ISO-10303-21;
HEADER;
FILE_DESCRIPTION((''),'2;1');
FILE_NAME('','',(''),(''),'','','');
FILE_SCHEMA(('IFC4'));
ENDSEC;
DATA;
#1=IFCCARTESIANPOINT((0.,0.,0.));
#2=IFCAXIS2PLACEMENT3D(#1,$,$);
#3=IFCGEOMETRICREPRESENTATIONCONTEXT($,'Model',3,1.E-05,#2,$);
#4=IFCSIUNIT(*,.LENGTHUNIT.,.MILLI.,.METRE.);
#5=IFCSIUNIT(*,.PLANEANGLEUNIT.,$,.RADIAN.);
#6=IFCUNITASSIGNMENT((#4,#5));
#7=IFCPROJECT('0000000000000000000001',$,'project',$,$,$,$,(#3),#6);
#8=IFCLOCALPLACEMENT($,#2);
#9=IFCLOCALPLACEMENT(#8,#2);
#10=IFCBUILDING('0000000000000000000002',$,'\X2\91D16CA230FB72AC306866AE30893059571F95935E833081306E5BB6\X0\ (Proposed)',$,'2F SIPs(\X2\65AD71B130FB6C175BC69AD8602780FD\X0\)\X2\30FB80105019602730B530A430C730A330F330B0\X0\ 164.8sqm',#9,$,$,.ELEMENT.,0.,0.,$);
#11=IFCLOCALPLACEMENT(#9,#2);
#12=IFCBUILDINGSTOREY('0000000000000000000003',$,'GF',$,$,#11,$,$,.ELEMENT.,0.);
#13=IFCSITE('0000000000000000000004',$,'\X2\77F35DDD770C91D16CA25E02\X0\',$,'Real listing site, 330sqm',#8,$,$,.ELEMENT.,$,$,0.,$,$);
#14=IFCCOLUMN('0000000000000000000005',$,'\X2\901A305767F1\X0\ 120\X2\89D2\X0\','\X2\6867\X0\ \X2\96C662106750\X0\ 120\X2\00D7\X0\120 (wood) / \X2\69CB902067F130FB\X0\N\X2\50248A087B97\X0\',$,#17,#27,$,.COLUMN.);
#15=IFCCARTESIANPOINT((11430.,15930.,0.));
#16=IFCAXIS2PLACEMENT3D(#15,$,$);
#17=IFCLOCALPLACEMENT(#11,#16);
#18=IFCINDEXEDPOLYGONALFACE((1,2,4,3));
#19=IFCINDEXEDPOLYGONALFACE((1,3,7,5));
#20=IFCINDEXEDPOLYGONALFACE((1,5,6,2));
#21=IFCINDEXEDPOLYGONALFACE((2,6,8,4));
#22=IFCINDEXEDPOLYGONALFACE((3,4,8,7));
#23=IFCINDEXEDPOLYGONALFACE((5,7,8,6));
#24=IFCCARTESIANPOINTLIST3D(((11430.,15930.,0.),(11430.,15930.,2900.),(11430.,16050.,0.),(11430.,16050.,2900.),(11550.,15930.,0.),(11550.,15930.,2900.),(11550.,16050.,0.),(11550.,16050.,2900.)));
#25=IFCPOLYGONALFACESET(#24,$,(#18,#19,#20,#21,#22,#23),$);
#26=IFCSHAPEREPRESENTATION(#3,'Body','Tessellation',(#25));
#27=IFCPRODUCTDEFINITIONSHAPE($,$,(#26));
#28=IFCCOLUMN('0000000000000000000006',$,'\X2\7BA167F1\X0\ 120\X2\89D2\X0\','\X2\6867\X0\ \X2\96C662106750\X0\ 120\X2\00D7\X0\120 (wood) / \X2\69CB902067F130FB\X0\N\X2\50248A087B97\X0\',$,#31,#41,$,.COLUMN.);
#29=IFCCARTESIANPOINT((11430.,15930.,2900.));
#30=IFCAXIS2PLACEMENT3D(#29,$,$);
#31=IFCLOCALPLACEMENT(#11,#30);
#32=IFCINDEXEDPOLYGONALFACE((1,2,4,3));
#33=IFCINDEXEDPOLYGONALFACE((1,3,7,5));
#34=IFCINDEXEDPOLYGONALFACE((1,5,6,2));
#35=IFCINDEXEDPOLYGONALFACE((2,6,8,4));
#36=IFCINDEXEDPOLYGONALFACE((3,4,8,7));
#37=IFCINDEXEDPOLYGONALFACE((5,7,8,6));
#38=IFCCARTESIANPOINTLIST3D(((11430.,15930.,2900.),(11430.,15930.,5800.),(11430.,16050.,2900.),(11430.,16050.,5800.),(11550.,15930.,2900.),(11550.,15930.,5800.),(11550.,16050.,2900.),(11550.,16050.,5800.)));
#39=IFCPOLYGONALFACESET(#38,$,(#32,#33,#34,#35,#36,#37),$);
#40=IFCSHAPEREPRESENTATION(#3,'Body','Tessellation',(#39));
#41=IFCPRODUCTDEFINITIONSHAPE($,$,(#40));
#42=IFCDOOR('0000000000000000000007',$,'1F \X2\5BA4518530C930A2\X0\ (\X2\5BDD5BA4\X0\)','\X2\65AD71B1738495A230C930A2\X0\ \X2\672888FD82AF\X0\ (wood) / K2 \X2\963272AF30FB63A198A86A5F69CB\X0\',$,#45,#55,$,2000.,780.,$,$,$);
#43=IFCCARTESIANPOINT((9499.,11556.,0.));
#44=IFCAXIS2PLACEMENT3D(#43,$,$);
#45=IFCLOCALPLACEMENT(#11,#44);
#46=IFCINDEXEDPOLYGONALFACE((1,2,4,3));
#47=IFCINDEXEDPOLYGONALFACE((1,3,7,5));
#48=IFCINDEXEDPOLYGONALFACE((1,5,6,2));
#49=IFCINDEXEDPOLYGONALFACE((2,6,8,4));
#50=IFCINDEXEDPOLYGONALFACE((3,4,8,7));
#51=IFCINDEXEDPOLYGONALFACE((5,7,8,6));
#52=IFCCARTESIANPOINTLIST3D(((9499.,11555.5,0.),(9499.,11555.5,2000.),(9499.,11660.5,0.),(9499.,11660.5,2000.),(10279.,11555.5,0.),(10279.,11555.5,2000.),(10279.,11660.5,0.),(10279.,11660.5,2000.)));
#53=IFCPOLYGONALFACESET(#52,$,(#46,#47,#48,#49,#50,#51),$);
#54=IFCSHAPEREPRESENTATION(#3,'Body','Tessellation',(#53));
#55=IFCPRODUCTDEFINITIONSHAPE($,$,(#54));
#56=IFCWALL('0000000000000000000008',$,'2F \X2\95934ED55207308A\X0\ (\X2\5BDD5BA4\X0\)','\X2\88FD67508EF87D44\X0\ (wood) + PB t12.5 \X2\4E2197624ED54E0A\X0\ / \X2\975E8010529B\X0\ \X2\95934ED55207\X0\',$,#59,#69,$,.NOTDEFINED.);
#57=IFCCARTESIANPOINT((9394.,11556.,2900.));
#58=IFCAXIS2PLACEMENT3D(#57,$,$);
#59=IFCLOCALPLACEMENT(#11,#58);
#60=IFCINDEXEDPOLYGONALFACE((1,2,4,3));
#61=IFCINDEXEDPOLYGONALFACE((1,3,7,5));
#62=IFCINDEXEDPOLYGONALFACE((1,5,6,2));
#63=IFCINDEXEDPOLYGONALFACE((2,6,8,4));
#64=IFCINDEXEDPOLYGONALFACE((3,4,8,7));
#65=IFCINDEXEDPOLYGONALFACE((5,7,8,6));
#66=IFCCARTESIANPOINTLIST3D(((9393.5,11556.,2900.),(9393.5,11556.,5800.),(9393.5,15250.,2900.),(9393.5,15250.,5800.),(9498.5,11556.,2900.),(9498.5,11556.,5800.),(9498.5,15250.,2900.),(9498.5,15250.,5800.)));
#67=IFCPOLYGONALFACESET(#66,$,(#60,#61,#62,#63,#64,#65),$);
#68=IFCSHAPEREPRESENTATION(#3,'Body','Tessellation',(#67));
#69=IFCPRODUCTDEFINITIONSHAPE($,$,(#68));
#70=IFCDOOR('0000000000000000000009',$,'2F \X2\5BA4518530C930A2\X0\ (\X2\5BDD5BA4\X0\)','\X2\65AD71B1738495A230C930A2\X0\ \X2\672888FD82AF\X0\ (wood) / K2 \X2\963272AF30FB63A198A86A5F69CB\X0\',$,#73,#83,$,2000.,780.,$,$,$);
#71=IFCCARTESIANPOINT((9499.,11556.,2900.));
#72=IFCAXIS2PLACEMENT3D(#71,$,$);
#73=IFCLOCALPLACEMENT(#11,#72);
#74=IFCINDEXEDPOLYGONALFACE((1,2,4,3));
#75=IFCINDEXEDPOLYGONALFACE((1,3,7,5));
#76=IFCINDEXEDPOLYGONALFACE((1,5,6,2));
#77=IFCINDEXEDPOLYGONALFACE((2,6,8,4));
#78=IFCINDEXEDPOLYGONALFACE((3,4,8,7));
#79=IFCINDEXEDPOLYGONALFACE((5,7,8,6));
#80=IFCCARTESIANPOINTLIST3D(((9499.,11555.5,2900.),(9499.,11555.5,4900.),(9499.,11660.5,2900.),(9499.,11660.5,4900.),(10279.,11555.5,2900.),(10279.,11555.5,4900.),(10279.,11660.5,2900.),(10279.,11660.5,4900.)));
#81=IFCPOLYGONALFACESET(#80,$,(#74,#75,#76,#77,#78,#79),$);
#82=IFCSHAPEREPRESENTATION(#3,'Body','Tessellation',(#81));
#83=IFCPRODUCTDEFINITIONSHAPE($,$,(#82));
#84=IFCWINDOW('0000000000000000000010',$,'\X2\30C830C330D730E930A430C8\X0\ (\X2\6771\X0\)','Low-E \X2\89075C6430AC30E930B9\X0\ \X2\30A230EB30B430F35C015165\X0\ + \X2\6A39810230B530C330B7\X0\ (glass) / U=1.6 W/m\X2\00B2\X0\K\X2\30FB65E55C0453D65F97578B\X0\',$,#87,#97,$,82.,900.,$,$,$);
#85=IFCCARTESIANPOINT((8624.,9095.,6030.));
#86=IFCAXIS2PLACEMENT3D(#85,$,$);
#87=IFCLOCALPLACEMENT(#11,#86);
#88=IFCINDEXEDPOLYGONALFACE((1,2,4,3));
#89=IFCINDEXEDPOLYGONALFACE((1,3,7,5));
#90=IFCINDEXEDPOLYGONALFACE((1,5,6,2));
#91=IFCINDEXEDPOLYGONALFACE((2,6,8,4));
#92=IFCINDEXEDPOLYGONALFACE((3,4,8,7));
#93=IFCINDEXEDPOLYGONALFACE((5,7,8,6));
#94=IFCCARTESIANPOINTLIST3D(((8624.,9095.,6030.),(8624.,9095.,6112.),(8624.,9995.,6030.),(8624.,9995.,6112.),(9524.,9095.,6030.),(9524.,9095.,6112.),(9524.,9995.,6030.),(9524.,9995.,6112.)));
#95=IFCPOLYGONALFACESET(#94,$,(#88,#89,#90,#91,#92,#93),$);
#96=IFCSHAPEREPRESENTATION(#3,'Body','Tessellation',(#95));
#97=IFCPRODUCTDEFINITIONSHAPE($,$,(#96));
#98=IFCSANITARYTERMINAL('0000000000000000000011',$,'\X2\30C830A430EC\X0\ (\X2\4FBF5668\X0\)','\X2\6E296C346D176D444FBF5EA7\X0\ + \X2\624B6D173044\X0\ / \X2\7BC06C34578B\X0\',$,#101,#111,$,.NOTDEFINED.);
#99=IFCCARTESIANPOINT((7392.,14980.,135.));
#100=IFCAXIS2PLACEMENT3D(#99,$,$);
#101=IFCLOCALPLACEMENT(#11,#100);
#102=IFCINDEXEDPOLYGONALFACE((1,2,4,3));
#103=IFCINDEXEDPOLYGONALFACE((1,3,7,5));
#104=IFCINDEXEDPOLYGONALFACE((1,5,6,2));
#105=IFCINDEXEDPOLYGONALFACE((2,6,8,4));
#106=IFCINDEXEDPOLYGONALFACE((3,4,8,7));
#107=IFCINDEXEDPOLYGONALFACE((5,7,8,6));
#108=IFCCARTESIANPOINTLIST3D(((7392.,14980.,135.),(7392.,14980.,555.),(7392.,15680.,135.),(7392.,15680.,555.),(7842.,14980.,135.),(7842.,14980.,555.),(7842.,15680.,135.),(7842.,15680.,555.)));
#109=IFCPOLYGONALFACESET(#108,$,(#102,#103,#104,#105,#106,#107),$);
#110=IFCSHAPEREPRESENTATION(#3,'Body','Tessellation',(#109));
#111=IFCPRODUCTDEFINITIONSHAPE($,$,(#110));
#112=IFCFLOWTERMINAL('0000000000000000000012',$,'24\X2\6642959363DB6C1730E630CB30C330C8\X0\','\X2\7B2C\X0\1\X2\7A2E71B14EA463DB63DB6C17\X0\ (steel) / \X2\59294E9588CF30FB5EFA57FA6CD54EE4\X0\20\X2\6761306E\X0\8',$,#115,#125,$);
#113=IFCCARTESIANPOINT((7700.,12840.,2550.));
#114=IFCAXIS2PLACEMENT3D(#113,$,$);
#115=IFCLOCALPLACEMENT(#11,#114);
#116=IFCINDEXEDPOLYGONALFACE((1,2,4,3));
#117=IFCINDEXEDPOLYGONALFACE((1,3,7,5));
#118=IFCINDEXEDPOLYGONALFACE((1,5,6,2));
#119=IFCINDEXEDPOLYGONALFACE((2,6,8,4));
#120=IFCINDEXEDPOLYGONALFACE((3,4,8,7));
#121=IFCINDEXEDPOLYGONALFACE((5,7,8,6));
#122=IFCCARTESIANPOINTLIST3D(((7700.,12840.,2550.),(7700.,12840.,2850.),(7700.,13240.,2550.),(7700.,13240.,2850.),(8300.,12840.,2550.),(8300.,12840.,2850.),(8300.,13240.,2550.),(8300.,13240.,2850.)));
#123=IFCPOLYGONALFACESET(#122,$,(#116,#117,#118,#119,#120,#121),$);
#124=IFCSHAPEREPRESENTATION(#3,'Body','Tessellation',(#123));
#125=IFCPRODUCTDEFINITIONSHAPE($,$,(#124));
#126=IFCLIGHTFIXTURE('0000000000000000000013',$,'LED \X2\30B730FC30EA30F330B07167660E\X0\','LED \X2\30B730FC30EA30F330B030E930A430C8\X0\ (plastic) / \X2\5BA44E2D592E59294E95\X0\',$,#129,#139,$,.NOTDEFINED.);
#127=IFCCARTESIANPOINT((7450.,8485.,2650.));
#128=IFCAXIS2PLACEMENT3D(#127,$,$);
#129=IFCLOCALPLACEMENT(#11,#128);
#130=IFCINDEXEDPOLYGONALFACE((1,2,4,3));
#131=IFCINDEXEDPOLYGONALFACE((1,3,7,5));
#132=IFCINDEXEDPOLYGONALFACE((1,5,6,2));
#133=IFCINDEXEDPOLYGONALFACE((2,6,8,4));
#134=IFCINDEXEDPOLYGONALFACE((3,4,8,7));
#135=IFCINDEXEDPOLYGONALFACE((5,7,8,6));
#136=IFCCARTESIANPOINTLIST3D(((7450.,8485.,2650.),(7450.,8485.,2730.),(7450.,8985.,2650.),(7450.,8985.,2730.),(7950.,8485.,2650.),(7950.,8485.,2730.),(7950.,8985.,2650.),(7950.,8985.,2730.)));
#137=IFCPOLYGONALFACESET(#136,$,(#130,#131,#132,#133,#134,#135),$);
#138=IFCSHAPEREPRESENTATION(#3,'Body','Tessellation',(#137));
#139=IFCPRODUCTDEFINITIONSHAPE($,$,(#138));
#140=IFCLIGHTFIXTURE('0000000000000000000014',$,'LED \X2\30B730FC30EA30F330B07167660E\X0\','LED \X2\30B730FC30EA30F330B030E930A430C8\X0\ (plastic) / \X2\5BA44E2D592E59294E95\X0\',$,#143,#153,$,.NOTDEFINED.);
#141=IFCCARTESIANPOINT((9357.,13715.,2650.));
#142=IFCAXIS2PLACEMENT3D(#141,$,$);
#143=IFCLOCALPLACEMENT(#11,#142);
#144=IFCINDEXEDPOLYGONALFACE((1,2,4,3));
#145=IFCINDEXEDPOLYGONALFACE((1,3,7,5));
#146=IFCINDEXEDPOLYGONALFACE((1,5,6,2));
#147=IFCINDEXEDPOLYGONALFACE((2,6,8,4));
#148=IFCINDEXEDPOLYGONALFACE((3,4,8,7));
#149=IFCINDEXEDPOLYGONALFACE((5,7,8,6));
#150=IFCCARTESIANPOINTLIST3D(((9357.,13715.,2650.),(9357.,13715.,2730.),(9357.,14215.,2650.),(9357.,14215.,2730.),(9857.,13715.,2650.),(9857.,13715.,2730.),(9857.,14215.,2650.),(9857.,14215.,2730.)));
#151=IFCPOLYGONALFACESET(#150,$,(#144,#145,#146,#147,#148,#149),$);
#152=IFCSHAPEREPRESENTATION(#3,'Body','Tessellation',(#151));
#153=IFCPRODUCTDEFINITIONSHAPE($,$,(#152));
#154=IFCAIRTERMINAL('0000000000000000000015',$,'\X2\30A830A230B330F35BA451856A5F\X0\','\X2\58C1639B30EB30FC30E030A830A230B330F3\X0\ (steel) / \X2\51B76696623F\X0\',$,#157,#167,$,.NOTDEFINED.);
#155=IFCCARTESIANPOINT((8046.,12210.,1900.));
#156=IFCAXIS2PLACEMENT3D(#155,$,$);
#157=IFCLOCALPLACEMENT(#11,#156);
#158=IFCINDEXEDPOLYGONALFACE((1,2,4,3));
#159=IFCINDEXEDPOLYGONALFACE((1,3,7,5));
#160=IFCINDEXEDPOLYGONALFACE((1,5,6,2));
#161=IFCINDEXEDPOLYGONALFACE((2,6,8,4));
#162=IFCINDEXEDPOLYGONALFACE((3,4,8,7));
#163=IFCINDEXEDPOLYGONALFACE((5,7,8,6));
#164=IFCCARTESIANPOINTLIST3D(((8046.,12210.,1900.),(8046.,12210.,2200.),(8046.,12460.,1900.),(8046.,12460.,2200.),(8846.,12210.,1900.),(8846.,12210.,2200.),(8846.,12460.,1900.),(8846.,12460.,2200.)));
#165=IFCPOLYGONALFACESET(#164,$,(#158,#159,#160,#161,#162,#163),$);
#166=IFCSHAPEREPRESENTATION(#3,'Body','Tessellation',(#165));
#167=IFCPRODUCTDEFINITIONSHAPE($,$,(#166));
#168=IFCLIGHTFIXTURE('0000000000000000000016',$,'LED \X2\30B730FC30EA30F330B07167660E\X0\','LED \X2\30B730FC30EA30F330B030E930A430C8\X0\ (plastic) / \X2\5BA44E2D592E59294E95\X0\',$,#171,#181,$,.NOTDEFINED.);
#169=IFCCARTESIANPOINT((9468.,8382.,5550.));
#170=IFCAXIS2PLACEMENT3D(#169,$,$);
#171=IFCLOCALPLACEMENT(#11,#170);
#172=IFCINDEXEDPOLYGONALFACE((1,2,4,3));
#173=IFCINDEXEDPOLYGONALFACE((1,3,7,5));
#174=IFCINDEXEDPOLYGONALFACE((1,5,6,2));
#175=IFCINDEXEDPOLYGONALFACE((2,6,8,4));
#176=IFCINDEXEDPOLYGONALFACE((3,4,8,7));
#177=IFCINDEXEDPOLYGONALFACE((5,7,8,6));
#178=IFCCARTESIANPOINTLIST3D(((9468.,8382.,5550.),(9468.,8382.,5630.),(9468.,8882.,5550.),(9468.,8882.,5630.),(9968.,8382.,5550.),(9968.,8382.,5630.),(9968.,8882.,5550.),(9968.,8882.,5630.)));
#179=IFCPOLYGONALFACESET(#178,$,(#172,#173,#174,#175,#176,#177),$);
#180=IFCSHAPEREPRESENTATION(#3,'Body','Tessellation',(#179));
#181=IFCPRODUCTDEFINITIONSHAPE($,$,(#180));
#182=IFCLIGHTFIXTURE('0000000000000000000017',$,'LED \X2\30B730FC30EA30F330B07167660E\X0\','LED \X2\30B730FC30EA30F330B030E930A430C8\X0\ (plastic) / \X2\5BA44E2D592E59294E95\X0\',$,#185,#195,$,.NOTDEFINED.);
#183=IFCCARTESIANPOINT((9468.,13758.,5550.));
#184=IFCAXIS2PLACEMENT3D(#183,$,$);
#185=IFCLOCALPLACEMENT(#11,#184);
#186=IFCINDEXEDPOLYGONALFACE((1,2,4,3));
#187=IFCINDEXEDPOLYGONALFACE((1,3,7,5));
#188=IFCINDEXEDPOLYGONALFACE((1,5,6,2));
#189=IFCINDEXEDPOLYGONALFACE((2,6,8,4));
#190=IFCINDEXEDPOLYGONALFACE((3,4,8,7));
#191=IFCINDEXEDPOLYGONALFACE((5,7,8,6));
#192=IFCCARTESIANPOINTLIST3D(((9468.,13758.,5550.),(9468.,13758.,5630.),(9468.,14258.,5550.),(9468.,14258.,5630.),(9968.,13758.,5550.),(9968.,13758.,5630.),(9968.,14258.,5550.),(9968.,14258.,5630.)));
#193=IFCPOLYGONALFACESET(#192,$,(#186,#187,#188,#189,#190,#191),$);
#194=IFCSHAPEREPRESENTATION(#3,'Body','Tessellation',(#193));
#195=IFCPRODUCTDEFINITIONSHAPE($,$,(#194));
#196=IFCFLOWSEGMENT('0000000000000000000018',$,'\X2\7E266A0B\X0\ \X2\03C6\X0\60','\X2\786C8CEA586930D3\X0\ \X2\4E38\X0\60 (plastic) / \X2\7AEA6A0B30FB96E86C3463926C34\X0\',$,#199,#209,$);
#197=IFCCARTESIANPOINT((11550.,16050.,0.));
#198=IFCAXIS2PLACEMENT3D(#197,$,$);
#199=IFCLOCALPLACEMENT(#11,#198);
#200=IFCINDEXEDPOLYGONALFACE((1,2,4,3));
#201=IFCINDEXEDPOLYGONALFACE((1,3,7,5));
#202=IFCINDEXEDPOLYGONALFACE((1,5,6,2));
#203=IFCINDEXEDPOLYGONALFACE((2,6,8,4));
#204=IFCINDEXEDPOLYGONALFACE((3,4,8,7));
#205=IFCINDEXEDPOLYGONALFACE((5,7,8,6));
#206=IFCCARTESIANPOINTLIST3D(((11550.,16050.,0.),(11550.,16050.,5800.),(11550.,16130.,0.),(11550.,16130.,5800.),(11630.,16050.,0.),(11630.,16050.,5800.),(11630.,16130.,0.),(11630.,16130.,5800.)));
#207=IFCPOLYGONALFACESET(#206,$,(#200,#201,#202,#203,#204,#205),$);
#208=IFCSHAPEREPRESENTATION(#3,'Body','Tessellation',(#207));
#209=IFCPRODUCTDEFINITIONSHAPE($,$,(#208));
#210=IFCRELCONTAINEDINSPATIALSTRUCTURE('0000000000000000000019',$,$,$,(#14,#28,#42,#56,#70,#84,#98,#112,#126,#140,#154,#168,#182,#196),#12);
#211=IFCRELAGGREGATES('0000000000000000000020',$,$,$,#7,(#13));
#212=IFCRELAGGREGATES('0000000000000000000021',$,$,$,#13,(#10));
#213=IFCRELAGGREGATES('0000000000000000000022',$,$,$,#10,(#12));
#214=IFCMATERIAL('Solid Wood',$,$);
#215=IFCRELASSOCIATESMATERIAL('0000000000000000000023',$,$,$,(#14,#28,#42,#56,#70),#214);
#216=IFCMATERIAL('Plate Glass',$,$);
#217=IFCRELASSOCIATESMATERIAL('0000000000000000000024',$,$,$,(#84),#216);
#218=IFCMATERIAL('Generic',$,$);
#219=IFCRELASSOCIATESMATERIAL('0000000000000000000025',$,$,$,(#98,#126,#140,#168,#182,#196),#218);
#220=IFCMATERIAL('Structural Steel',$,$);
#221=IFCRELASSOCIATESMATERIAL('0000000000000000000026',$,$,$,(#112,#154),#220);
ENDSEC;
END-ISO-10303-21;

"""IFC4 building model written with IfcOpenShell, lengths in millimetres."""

from ifc_helpers import new_model, si_unit, frame, frame_2d, origin, place, context, project, spatial, rectangle, extrude, material, element, save


model = new_model("IFC4")

# Units and contexts
model_context = context("Model", 3, precision=1e-05, world=origin())
ifc_project = project(units=[si_unit("LENGTHUNIT", "METRE", prefix="MILLI"), si_unit("PLANEANGLEUNIT", "RADIAN")], contexts=[model_context])

# Site, building, storey
site_placement = place(None, origin())
site = spatial("IfcSite", under=ifc_project, at=site_placement, Name="石川県金沢市", ObjectType="Real listing site, 330sqm", CompositionType="ELEMENT", RefElevation=0.0)
building_placement = place(site_placement, origin())
building = spatial("IfcBuilding", under=site, at=building_placement, Name="金沢・犬と暮らす土間広めの家 (Proposed)", ObjectType="2F SIPs(断熱・気密高性能)・耐候性サイディング 164.8sqm", CompositionType="ELEMENT", ElevationOfRefHeight=0.0, ElevationOfTerrain=0.0)
storey_placement = place(building_placement, origin())
storey = spatial("IfcBuildingStorey", under=building, at=storey_placement, Name="GF", CompositionType="ELEMENT", Elevation=0.0)

# Columns
ifc_material_1 = material(Name="Solid Wood")
column_1_placement = place(storey_placement, frame((11430.0, 15930.0, 0.0)))
element("IfcColumn", 1, at=column_1_placement, inside=storey, material=ifc_material_1, Name="通し柱 120角", Description="桧 集成材 120×120 (wood) / 構造柱・N値計算", PredefinedType="COLUMN", context=model_context, shape_type="SweptSolid", body=[
    extrude(rectangle(XDim=120.0, YDim=120.0, at=frame_2d((60.0, 60.0))), frame((11430.0, 15930.0, 0.0)), (0.0, 0.0, 1.0), 2900.0),
])
column_2_placement = place(storey_placement, frame((11430.0, 15930.0, 2900.0)))
element("IfcColumn", 2, at=column_2_placement, inside=storey, material=ifc_material_1, Name="管柱 120角", Description="桧 集成材 120×120 (wood) / 構造柱・N値計算", PredefinedType="COLUMN", context=model_context, shape_type="SweptSolid", body=[
    extrude(rectangle(XDim=120.0, YDim=120.0, at=frame_2d((60.0, 60.0))), frame((11430.0, 15930.0, 2900.0)), (0.0, 0.0, 1.0), 2900.0),
])

# Door
door_1_placement = place(storey_placement, frame((9499.0, 11556.0, 0.0)))
element("IfcDoor", 3, at=door_1_placement, inside=storey, material=ifc_material_1, Name="1F 室内ドア (寝室)", Description="断熱玄関ドア 木製芯 (wood) / K2 防犯・採風機構", OverallHeight=2000.0, OverallWidth=780.0, context=model_context, shape_type="SweptSolid", body=[
    extrude(rectangle(XDim=780.0, YDim=105.0, at=frame_2d((390.0, 52.0))), frame((9499.0, 11556.0, 0.0)), (0.0, 0.0, 1.0), 2000.0),
])

# Wall
wall_1_placement = place(storey_placement, frame((9394.0, 11556.0, 2900.0)))
element("IfcWall", 4, at=wall_1_placement, inside=storey, material=ifc_material_1, Name="2F 間仕切り (寝室)", Description="製材軸組 (wood) + PB t12.5 両面仕上 / 非耐力 間仕切", PredefinedType="NOTDEFINED", context=model_context, shape_type="SweptSolid", body=[
    extrude(rectangle(XDim=105.0, YDim=3694.0, at=frame_2d((52.0, 1847.0))), frame((9394.0, 11556.0, 2900.0)), (0.0, 0.0, 1.0), 2900.0),
])

# Door
door_2_placement = place(storey_placement, frame((9499.0, 11556.0, 2900.0)))
element("IfcDoor", 5, at=door_2_placement, inside=storey, material=ifc_material_1, Name="2F 室内ドア (寝室)", Description="断熱玄関ドア 木製芯 (wood) / K2 防犯・採風機構", OverallHeight=2000.0, OverallWidth=780.0, context=model_context, shape_type="SweptSolid", body=[
    extrude(rectangle(XDim=780.0, YDim=105.0, at=frame_2d((390.0, 52.0))), frame((9499.0, 11556.0, 2900.0)), (0.0, 0.0, 1.0), 2000.0),
])

# Window
ifc_material_2 = material(Name="Plate Glass")
window_placement = place(storey_placement, frame((8624.0, 9095.0, 6030.0)))
element("IfcWindow", 6, at=window_placement, inside=storey, material=ifc_material_2, Name="トップライト (東)", Description="Low-E 複層ガラス アルゴン封入 + 樹脂サッシ (glass) / U=1.6 W/m²K・日射取得型", OverallHeight=82.0, OverallWidth=900.0, context=model_context, shape_type="SweptSolid", body=[
    extrude(rectangle(XDim=900.0, YDim=900.0, at=frame_2d((450.0, 450.0))), frame((8624.0, 9095.0, 6030.0)), (0.0, 0.0, 1.0), 82.0),
])

# Sanitary terminal
ifc_material_3 = material(Name="Generic")
sanitary_terminal_placement = place(storey_placement, frame((7392.0, 14980.0, 135.0)))
element("IfcSanitaryTerminal", 7, at=sanitary_terminal_placement, inside=storey, material=ifc_material_3, Name="トイレ (便器)", Description="温水洗浄便座 + 手洗い / 節水型", PredefinedType="NOTDEFINED", context=model_context, shape_type="SweptSolid", body=[
    extrude(rectangle(XDim=450.0, YDim=700.0, at=frame_2d((225.0, 350.0))), frame((7392.0, 14980.0, 135.0)), (0.0, 0.0, 1.0), 420.0),
])

# Flow terminal
ifc_material_4 = material(Name="Structural Steel")
flow_terminal_placement = place(storey_placement, frame((7700.0, 12840.0, 2550.0)))
element("IfcFlowTerminal", 8, at=flow_terminal_placement, inside=storey, material=ifc_material_4, Name="24時間換気ユニット", Description="第1種熱交換換気 (steel) / 天井裏・建基法令20条の8", context=model_context, shape_type="SweptSolid", body=[
    extrude(rectangle(XDim=600.0, YDim=400.0, at=frame_2d((300.0, 200.0))), frame((7700.0, 12840.0, 2550.0)), (0.0, 0.0, 1.0), 300.0),
])

# Light fixtures
light_fixture_1_placement = place(storey_placement, frame((7450.0, 8485.0, 2650.0)))
element("IfcLightFixture", 9, at=light_fixture_1_placement, inside=storey, material=ifc_material_3, Name="LED シーリング照明", Description="LED シーリングライト (plastic) / 室中央天井", PredefinedType="NOTDEFINED", context=model_context, shape_type="SweptSolid", body=[
    extrude(rectangle(XDim=500.0, YDim=500.0, at=frame_2d((250.0, 250.0))), frame((7450.0, 8485.0, 2650.0)), (0.0, 0.0, 1.0), 80.0),
])
light_fixture_2_placement = place(storey_placement, frame((9357.0, 13715.0, 2650.0)))
element("IfcLightFixture", 10, at=light_fixture_2_placement, inside=storey, material=ifc_material_3, Name="LED シーリング照明", Description="LED シーリングライト (plastic) / 室中央天井", PredefinedType="NOTDEFINED", context=model_context, shape_type="SweptSolid", body=[
    extrude(rectangle(XDim=500.0, YDim=500.0, at=frame_2d((250.0, 250.0))), frame((9357.0, 13715.0, 2650.0)), (0.0, 0.0, 1.0), 80.0),
])

# Air terminal
air_terminal_placement = place(storey_placement, frame((8046.0, 12210.0, 1900.0)))
element("IfcAirTerminal", 11, at=air_terminal_placement, inside=storey, material=ifc_material_4, Name="エアコン室内機", Description="壁掛ルームエアコン (steel) / 冷暖房", PredefinedType="NOTDEFINED", context=model_context, shape_type="SweptSolid", body=[
    extrude(rectangle(XDim=800.0, YDim=250.0, at=frame_2d((400.0, 125.0))), frame((8046.0, 12210.0, 1900.0)), (0.0, 0.0, 1.0), 300.0),
])

# Light fixtures
light_fixture_3_placement = place(storey_placement, frame((9468.0, 8382.0, 5550.0)))
element("IfcLightFixture", 12, at=light_fixture_3_placement, inside=storey, material=ifc_material_3, Name="LED シーリング照明", Description="LED シーリングライト (plastic) / 室中央天井", PredefinedType="NOTDEFINED", context=model_context, shape_type="SweptSolid", body=[
    extrude(rectangle(XDim=500.0, YDim=500.0, at=frame_2d((250.0, 250.0))), frame((9468.0, 8382.0, 5550.0)), (0.0, 0.0, 1.0), 80.0),
])
light_fixture_4_placement = place(storey_placement, frame((9468.0, 13758.0, 5550.0)))
element("IfcLightFixture", 13, at=light_fixture_4_placement, inside=storey, material=ifc_material_3, Name="LED シーリング照明", Description="LED シーリングライト (plastic) / 室中央天井", PredefinedType="NOTDEFINED", context=model_context, shape_type="SweptSolid", body=[
    extrude(rectangle(XDim=500.0, YDim=500.0, at=frame_2d((250.0, 250.0))), frame((9468.0, 13758.0, 5550.0)), (0.0, 0.0, 1.0), 80.0),
])

# Flow segment
flow_segment_placement = place(storey_placement, frame((11550.0, 16050.0, 0.0)))
element("IfcFlowSegment", 14, at=flow_segment_placement, inside=storey, material=ifc_material_3, Name="縦樋 φ60", Description="硬質塩ビ 丸60 (plastic) / 竪樋・雨水排水", context=model_context, shape_type="SweptSolid", body=[
    extrude(rectangle(XDim=80.0, YDim=80.0, at=frame_2d((40.0, 40.0))), frame((11550.0, 16050.0, 0.0)), (0.0, 0.0, 1.0), 5800.0),
])

save(model, "model.ifc")
